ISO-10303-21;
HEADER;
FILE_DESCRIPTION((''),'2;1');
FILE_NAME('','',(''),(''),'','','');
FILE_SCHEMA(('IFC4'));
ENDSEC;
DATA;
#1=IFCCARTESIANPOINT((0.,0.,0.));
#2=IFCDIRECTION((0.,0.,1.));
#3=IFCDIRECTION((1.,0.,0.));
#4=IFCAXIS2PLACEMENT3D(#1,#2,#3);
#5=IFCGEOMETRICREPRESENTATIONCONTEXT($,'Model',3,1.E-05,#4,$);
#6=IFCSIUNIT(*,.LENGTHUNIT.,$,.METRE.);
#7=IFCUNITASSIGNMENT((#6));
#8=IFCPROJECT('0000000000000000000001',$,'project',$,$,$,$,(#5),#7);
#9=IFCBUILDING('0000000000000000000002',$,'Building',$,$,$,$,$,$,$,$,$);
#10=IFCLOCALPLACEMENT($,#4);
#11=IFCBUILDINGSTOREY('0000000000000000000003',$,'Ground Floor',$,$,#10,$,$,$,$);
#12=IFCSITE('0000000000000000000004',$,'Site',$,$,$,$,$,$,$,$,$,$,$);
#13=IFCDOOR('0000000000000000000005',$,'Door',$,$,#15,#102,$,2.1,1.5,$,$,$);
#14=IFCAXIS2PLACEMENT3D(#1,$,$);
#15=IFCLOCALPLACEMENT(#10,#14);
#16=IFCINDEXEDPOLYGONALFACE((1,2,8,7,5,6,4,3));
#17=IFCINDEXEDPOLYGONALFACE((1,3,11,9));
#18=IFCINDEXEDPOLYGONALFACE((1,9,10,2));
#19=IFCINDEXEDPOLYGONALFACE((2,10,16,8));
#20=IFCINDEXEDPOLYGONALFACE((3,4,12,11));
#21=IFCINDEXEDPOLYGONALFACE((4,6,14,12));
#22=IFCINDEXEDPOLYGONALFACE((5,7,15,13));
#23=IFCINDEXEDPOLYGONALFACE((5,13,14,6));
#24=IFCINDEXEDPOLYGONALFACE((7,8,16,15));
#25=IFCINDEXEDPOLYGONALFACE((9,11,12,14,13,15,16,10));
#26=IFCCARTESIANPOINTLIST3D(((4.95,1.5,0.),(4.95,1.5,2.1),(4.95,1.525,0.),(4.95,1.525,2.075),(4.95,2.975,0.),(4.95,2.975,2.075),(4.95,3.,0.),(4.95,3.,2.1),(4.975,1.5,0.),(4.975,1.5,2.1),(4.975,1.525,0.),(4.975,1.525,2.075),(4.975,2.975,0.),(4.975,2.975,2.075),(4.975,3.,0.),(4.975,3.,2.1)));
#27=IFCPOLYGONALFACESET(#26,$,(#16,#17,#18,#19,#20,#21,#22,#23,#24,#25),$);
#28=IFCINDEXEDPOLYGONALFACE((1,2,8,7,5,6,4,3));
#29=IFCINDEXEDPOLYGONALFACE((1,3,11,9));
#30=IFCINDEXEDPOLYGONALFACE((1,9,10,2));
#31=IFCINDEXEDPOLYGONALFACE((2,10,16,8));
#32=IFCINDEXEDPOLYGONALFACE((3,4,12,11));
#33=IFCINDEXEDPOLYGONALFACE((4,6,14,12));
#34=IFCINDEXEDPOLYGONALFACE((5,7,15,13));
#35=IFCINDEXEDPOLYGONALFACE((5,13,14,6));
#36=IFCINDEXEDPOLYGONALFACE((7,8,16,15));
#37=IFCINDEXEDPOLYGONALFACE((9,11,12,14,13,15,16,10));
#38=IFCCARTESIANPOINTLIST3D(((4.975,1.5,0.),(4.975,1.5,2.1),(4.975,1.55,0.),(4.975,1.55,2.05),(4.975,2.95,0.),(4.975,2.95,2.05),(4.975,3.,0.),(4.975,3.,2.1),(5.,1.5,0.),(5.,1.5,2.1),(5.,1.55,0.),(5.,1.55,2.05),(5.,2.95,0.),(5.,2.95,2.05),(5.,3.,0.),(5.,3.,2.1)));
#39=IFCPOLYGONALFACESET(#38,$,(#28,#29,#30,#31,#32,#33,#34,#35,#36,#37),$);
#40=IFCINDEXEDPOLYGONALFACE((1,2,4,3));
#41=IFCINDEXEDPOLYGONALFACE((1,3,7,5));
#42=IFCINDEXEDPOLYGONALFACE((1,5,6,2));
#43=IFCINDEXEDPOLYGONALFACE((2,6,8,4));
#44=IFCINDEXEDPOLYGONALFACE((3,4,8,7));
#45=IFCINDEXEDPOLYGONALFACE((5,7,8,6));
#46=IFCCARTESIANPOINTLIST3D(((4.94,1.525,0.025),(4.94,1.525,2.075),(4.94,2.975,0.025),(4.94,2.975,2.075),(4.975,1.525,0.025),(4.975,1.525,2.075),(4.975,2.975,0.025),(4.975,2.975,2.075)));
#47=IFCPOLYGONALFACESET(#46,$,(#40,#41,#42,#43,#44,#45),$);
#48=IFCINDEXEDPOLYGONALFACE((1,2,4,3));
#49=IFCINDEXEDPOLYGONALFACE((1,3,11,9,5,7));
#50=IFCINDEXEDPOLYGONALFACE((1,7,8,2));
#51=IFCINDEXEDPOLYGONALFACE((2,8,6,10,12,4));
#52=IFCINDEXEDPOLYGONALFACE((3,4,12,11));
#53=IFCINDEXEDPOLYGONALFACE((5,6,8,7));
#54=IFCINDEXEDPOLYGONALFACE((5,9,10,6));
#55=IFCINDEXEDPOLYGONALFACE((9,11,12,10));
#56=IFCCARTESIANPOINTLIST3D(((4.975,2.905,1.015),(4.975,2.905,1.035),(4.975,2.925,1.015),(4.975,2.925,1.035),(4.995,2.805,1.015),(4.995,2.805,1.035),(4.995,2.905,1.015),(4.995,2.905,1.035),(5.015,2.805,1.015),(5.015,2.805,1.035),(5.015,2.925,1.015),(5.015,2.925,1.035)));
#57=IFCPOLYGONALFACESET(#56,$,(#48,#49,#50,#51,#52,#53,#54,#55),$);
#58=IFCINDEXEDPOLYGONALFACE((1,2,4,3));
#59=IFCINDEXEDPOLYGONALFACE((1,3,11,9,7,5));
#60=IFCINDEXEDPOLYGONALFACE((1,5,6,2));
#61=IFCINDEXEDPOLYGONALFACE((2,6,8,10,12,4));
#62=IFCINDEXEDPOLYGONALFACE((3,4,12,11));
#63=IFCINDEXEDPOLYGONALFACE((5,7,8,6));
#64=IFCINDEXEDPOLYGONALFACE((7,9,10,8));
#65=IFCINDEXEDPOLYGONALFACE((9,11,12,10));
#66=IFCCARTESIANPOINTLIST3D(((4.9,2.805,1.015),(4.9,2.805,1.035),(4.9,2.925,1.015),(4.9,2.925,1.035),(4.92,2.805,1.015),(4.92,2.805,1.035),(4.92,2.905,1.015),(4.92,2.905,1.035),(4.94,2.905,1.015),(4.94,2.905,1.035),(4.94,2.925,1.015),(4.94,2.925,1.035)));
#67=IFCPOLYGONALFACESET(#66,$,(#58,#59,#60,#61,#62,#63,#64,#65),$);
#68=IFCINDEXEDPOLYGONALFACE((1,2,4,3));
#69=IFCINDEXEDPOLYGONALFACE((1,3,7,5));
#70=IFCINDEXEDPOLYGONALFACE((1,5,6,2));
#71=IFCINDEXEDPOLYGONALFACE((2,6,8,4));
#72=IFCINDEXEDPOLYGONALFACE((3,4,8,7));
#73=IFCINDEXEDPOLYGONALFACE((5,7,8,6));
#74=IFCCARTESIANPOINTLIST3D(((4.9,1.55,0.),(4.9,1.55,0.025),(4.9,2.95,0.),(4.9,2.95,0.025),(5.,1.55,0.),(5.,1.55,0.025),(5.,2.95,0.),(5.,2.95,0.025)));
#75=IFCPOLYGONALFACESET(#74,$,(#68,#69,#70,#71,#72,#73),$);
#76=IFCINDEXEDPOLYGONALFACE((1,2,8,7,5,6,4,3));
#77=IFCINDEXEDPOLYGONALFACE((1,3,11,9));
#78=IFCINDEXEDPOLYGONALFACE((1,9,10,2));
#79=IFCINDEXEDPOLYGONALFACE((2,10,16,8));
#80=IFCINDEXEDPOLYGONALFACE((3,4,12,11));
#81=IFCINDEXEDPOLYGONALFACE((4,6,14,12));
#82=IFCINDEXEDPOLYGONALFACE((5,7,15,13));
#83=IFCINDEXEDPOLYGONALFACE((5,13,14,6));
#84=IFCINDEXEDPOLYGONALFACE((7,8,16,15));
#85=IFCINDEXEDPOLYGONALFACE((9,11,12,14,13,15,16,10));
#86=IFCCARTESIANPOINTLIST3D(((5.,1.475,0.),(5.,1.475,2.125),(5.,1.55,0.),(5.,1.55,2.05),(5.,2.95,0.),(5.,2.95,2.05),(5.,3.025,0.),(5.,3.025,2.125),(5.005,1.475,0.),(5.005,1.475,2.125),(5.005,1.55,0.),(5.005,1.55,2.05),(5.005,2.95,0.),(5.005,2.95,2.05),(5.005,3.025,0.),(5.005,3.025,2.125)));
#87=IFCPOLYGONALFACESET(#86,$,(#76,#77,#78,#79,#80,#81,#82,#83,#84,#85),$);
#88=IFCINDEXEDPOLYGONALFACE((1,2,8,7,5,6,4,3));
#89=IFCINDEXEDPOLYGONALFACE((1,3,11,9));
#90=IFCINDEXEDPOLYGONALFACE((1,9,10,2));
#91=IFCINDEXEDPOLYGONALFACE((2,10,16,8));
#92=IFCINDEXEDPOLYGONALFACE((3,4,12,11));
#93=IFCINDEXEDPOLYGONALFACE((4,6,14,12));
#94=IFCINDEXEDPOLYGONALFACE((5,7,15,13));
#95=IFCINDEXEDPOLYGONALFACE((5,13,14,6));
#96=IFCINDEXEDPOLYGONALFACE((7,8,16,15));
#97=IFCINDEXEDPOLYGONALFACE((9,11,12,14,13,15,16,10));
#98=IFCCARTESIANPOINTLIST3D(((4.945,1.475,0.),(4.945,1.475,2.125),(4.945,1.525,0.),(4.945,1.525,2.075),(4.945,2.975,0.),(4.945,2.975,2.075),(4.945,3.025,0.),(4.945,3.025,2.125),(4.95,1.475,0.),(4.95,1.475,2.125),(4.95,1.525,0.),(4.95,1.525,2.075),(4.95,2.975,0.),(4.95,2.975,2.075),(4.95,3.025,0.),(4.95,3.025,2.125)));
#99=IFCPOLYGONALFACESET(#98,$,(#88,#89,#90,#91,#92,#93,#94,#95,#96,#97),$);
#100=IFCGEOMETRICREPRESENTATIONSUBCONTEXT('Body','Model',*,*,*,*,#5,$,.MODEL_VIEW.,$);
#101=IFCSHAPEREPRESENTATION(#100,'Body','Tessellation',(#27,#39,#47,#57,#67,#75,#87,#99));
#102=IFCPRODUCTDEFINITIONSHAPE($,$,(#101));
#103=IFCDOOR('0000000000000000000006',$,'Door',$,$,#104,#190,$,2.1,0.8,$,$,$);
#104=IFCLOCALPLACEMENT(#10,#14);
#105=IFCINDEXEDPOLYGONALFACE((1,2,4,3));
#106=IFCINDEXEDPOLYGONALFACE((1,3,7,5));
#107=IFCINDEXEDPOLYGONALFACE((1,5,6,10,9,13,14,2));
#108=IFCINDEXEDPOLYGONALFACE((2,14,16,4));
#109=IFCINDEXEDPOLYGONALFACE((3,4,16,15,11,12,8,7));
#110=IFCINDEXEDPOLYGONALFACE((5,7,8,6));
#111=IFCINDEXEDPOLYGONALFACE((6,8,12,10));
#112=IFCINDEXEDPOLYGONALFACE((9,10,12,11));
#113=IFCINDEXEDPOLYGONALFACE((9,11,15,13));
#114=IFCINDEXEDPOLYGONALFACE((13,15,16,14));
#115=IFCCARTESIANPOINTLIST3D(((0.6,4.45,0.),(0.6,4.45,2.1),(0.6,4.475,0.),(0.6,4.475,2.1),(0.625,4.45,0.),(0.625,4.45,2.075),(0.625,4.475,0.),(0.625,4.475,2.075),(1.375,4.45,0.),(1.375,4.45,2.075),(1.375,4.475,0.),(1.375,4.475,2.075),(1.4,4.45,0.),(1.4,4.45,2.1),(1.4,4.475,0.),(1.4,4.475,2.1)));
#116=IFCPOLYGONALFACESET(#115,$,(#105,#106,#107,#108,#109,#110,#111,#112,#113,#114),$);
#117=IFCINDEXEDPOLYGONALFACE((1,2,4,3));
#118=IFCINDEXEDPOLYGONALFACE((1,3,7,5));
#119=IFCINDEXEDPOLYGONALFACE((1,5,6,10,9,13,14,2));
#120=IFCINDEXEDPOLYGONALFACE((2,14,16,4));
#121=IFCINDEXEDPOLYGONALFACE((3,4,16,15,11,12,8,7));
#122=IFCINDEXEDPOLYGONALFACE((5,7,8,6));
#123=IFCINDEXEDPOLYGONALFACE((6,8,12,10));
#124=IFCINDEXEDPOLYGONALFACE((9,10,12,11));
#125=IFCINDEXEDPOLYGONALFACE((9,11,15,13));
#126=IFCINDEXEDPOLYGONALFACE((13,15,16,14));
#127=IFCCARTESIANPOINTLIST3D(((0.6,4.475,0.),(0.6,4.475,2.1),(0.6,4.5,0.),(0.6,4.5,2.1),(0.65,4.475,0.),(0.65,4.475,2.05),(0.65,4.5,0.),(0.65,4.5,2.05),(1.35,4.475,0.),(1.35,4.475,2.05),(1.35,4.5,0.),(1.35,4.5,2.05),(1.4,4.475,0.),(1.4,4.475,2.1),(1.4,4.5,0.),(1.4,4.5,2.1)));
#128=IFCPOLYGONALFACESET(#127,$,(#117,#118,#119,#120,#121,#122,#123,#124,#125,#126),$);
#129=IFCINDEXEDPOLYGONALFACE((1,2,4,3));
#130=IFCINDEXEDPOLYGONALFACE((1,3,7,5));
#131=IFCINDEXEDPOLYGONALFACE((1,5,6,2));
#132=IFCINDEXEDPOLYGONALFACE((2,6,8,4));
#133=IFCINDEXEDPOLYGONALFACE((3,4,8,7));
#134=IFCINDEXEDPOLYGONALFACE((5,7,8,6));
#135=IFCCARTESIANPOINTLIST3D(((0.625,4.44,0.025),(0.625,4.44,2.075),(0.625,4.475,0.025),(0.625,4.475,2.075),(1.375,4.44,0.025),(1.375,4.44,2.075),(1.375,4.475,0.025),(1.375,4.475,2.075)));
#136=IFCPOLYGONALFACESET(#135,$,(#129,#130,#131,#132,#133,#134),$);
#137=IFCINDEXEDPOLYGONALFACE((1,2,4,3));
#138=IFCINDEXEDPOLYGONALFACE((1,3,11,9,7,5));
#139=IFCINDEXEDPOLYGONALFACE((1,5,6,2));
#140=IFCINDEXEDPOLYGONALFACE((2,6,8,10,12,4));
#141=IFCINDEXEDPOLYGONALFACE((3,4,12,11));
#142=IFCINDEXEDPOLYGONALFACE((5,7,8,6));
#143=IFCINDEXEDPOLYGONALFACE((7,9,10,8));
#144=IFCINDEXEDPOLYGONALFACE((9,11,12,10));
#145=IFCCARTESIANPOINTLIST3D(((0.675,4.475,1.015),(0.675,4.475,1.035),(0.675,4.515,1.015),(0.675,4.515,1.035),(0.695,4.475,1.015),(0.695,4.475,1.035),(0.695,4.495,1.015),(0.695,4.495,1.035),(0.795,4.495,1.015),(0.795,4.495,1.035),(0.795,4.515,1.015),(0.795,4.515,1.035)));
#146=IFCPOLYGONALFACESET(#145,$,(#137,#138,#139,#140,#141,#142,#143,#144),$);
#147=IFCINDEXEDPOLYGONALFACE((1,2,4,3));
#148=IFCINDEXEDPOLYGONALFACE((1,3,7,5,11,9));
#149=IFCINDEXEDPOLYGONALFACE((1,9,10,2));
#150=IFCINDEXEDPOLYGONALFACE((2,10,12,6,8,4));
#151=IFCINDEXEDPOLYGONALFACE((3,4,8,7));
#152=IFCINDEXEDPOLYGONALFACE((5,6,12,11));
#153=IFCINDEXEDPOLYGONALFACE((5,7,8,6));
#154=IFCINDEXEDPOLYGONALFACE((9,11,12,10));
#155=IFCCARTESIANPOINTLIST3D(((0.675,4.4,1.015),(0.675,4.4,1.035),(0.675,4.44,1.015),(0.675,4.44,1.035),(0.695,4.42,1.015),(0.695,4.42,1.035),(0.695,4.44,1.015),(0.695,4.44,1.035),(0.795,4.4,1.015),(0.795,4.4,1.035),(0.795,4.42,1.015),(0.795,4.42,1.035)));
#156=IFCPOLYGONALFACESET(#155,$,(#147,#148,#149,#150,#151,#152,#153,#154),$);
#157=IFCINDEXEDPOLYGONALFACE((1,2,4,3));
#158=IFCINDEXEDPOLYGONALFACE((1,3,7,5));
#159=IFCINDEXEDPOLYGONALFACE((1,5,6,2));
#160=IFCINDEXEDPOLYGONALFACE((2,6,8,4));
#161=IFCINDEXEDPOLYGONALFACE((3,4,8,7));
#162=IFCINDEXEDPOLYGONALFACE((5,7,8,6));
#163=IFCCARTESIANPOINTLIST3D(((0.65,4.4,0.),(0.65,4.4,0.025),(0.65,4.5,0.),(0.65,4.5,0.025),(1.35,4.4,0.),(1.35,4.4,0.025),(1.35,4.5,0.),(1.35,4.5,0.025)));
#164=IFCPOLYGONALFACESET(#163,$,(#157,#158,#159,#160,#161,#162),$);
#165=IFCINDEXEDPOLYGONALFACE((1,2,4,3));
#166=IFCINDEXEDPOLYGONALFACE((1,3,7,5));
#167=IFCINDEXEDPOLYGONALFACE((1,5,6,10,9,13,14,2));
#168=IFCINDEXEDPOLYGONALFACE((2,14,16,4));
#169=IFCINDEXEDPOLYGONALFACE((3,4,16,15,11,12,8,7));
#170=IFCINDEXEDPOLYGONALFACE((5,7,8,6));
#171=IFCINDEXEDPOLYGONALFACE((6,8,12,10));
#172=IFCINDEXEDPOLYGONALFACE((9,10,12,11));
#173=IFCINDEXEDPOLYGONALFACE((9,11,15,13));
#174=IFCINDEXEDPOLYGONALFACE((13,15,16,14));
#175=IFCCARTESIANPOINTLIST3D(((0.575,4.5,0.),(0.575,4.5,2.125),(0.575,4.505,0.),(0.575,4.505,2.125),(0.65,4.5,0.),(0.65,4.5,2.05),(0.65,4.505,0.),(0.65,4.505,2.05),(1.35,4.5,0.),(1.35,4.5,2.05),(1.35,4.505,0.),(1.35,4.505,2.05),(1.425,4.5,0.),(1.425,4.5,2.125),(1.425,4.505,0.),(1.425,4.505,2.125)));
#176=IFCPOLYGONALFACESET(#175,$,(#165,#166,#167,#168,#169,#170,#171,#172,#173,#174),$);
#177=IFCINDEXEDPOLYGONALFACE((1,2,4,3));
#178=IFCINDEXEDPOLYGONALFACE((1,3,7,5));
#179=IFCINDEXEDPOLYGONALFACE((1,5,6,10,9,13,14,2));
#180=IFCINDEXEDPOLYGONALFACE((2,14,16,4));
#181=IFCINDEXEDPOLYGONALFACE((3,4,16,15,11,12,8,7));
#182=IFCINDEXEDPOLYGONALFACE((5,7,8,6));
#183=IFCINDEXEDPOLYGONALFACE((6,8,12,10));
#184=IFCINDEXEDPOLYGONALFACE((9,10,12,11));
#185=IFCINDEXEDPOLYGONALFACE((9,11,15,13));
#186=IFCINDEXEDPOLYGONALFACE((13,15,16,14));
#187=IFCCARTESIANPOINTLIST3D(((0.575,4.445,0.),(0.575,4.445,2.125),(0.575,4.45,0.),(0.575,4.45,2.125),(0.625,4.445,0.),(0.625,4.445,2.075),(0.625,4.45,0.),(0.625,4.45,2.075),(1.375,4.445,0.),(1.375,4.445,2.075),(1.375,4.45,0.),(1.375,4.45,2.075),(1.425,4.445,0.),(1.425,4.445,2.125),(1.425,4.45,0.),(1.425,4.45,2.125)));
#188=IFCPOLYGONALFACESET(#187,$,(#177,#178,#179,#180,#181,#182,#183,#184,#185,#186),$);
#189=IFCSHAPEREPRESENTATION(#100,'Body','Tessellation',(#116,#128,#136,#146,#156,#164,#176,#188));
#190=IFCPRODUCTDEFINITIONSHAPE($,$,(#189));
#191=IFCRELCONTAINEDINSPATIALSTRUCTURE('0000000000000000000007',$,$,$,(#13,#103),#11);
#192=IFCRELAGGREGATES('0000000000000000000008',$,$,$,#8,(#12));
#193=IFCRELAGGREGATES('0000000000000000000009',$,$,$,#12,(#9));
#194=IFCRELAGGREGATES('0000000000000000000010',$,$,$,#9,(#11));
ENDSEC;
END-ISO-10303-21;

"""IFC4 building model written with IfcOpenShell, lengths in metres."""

from ifc_helpers import new_model, si_unit, frame, origin_with_axes, place, context, subcontext, project, spatial, line, indexed_curve, outline, extrude, element, save


model = new_model("IFC4")

# Units and contexts
model_context = context("Model", 3, precision=1e-05, world=origin_with_axes())
body_context = subcontext(model_context, "Body", "Model", "MODEL_VIEW")
ifc_project = project(units=[si_unit("LENGTHUNIT", "METRE")], contexts=[model_context])

# Site, building, storey
site = spatial("IfcSite", under=ifc_project, Name="Site")
building = spatial("IfcBuilding", under=site, Name="Building")
storey_placement = place(None, origin_with_axes())
storey = spatial("IfcBuildingStorey", under=building, at=storey_placement, Name="Ground Floor")

# Doors
door_1_placement = place(storey_placement, frame((5.0, 1.5, 0.0), z_axis=(0.0, 0.0, 1.0), x_axis=(0.0, 1.0, 0.0)))
element("IfcDoor", 1, at=door_1_placement, inside=storey, Name="Door", OverallHeight=2.1, OverallWidth=1.5, context=body_context, shape_type="SweptSolid", body=[
    extrude(outline(indexed_curve([(0.0, 0.0), (0.0, 2.1), (1.5, 2.1), (1.5, 0.0), (1.475, 0.0), (1.475, 2.075), (0.025, 2.075), (0.025, 0.0)], segments=[line(1, 2, 3, 4, 5, 6, 7, 8, 1)])), frame((0.0, 0.025, 0.0), z_axis=(0.0, -1.0, 0.0), x_axis=(1.0, 0.0, 0.0)), (0.0, 0.0, -1.0), 0.025),
    extrude(outline(indexed_curve([(0.0, 0.0), (0.0, 2.1), (1.5, 2.1), (1.5, 0.0), (1.45, 0.0), (1.45, 2.05), (0.05, 2.05), (0.05, 0.0)], segments=[line(1, 2, 3, 4, 5, 6, 7, 8, 1)])), frame((0.0, 0.0, 0.0), z_axis=(0.0, -1.0, 0.0), x_axis=(1.0, 0.0, 0.0)), (0.0, 0.0, -1.0), 0.025),
    extrude(outline(indexed_curve([(0.0, 0.0), (1.45, 0.0), (1.45, 0.035), (0.0, 0.035)], segments=[line(1, 2, 3, 4, 1)])), frame((0.025, 0.025, 0.025), z_axis=(0.0, 0.0, 1.0), x_axis=(1.0, 0.0, 0.0)), (0.0, 0.0, 1.0), 2.05),
    extrude(outline(indexed_curve([(0.0, 0.0), (0.0, -0.04), (-0.12, -0.04), (-0.12, -0.02), (-0.02, -0.02), (-0.02, 0.0)], segments=[line(1, 2, 3, 4, 5, 6, 1)])), frame((1.425, 0.025, 1.015), z_axis=(0.0, 0.0, 1.0), x_axis=(1.0, 0.0, 0.0)), (0.0, 0.0, 1.0), 0.02),
    extrude(outline(indexed_curve([(0.0, 0.0), (0.0, 0.04), (-0.12, 0.04), (-0.12, 0.02), (-0.02, 0.02), (-0.02, 0.0)], segments=[line(1, 2, 3, 4, 5, 6, 1)])), frame((1.425, 0.06, 1.015), z_axis=(0.0, 0.0, 1.0), x_axis=(1.0, 0.0, 0.0)), (0.0, 0.0, 1.0), 0.02),
    extrude(outline(indexed_curve([(0.0, 0.0), (1.4, 0.0), (1.4, 0.1), (0.0, 0.1)], segments=[line(1, 2, 3, 4, 1)])), frame((0.05, 0.0, 0.0), z_axis=(0.0, 0.0, 1.0), x_axis=(1.0, 0.0, 0.0)), (0.0, 0.0, 1.0), 0.025),
    extrude(outline(indexed_curve([(0.0, 0.0), (0.0, 2.125), (1.55, 2.125), (1.55, 0.0), (1.475, 0.0), (1.475, 2.05), (0.075, 2.05), (0.075, 0.0)], segments=[line(1, 2, 3, 4, 5, 6, 7, 8, 1)])), frame((-0.025, -0.005, 0.0), z_axis=(0.0, -1.0, 0.0), x_axis=(1.0, 0.0, 0.0)), (0.0, 0.0, -1.0), 0.005),
    extrude(outline(indexed_curve([(0.0, 0.0), (0.0, 2.125), (1.55, 2.125), (1.55, 0.0), (1.5, 0.0), (1.5, 2.075), (0.05, 2.075), (0.05, 0.0)], segments=[line(1, 2, 3, 4, 5, 6, 7, 8, 1)])), frame((-0.025, 0.05, 0.0), z_axis=(0.0, -1.0, 0.0), x_axis=(1.0, 0.0, 0.0)), (0.0, 0.0, -1.0), 0.005),
])
door_2_placement = place(storey_placement, frame((1.4, 4.5, 0.0), z_axis=(0.0, 0.0, 1.0), x_axis=(-1.0, 0.0, 0.0)))
element("IfcDoor", 2, at=door_2_placement, inside=storey, Name="Door", OverallHeight=2.1, OverallWidth=0.8, context=body_context, shape_type="SweptSolid", body=[
    extrude(outline(indexed_curve([(0.0, 0.0), (0.0, 2.1), (0.8, 2.1), (0.8, 0.0), (0.775, 0.0), (0.775, 2.075), (0.025, 2.075), (0.025, 0.0)], segments=[line(1, 2, 3, 4, 5, 6, 7, 8, 1)])), frame((0.0, 0.025, 0.0), z_axis=(0.0, -1.0, 0.0), x_axis=(1.0, 0.0, 0.0)), (0.0, 0.0, -1.0), 0.025),
    extrude(outline(indexed_curve([(0.0, 0.0), (0.0, 2.1), (0.8, 2.1), (0.8, 0.0), (0.75, 0.0), (0.75, 2.05), (0.05, 2.05), (0.05, 0.0)], segments=[line(1, 2, 3, 4, 5, 6, 7, 8, 1)])), frame((0.0, 0.0, 0.0), z_axis=(0.0, -1.0, 0.0), x_axis=(1.0, 0.0, 0.0)), (0.0, 0.0, -1.0), 0.025),
    extrude(outline(indexed_curve([(0.0, 0.0), (0.75, 0.0), (0.75, 0.035), (0.0, 0.035)], segments=[line(1, 2, 3, 4, 1)])), frame((0.025, 0.025, 0.025), z_axis=(0.0, 0.0, 1.0), x_axis=(1.0, 0.0, 0.0)), (0.0, 0.0, 1.0), 2.05),
    extrude(outline(indexed_curve([(0.0, 0.0), (0.0, -0.04), (-0.12, -0.04), (-0.12, -0.02), (-0.02, -0.02), (-0.02, 0.0)], segments=[line(1, 2, 3, 4, 5, 6, 1)])), frame((0.725, 0.025, 1.015), z_axis=(0.0, 0.0, 1.0), x_axis=(1.0, 0.0, 0.0)), (0.0, 0.0, 1.0), 0.02),
    extrude(outline(indexed_curve([(0.0, 0.0), (0.0, 0.04), (-0.12, 0.04), (-0.12, 0.02), (-0.02, 0.02), (-0.02, 0.0)], segments=[line(1, 2, 3, 4, 5, 6, 1)])), frame((0.725, 0.06, 1.015), z_axis=(0.0, 0.0, 1.0), x_axis=(1.0, 0.0, 0.0)), (0.0, 0.0, 1.0), 0.02),
    extrude(outline(indexed_curve([(0.0, 0.0), (0.7, 0.0), (0.7, 0.1), (0.0, 0.1)], segments=[line(1, 2, 3, 4, 1)])), frame((0.05, 0.0, 0.0), z_axis=(0.0, 0.0, 1.0), x_axis=(1.0, 0.0, 0.0)), (0.0, 0.0, 1.0), 0.025),
    extrude(outline(indexed_curve([(0.0, 0.0), (0.0, 2.125), (0.85, 2.125), (0.85, 0.0), (0.775, 0.0), (0.775, 2.05), (0.075, 2.05), (0.075, 0.0)], segments=[line(1, 2, 3, 4, 5, 6, 7, 8, 1)])), frame((-0.025, -0.005, 0.0), z_axis=(0.0, -1.0, 0.0), x_axis=(1.0, 0.0, 0.0)), (0.0, 0.0, -1.0), 0.005),
    extrude(outline(indexed_curve([(0.0, 0.0), (0.0, 2.125), (0.85, 2.125), (0.85, 0.0), (0.8, 0.0), (0.8, 2.075), (0.05, 2.075), (0.05, 0.0)], segments=[line(1, 2, 3, 4, 5, 6, 7, 8, 1)])), frame((-0.025, 0.05, 0.0), z_axis=(0.0, -1.0, 0.0), x_axis=(1.0, 0.0, 0.0)), (0.0, 0.0, -1.0), 0.005),
])

save(model, "model.ifc")
